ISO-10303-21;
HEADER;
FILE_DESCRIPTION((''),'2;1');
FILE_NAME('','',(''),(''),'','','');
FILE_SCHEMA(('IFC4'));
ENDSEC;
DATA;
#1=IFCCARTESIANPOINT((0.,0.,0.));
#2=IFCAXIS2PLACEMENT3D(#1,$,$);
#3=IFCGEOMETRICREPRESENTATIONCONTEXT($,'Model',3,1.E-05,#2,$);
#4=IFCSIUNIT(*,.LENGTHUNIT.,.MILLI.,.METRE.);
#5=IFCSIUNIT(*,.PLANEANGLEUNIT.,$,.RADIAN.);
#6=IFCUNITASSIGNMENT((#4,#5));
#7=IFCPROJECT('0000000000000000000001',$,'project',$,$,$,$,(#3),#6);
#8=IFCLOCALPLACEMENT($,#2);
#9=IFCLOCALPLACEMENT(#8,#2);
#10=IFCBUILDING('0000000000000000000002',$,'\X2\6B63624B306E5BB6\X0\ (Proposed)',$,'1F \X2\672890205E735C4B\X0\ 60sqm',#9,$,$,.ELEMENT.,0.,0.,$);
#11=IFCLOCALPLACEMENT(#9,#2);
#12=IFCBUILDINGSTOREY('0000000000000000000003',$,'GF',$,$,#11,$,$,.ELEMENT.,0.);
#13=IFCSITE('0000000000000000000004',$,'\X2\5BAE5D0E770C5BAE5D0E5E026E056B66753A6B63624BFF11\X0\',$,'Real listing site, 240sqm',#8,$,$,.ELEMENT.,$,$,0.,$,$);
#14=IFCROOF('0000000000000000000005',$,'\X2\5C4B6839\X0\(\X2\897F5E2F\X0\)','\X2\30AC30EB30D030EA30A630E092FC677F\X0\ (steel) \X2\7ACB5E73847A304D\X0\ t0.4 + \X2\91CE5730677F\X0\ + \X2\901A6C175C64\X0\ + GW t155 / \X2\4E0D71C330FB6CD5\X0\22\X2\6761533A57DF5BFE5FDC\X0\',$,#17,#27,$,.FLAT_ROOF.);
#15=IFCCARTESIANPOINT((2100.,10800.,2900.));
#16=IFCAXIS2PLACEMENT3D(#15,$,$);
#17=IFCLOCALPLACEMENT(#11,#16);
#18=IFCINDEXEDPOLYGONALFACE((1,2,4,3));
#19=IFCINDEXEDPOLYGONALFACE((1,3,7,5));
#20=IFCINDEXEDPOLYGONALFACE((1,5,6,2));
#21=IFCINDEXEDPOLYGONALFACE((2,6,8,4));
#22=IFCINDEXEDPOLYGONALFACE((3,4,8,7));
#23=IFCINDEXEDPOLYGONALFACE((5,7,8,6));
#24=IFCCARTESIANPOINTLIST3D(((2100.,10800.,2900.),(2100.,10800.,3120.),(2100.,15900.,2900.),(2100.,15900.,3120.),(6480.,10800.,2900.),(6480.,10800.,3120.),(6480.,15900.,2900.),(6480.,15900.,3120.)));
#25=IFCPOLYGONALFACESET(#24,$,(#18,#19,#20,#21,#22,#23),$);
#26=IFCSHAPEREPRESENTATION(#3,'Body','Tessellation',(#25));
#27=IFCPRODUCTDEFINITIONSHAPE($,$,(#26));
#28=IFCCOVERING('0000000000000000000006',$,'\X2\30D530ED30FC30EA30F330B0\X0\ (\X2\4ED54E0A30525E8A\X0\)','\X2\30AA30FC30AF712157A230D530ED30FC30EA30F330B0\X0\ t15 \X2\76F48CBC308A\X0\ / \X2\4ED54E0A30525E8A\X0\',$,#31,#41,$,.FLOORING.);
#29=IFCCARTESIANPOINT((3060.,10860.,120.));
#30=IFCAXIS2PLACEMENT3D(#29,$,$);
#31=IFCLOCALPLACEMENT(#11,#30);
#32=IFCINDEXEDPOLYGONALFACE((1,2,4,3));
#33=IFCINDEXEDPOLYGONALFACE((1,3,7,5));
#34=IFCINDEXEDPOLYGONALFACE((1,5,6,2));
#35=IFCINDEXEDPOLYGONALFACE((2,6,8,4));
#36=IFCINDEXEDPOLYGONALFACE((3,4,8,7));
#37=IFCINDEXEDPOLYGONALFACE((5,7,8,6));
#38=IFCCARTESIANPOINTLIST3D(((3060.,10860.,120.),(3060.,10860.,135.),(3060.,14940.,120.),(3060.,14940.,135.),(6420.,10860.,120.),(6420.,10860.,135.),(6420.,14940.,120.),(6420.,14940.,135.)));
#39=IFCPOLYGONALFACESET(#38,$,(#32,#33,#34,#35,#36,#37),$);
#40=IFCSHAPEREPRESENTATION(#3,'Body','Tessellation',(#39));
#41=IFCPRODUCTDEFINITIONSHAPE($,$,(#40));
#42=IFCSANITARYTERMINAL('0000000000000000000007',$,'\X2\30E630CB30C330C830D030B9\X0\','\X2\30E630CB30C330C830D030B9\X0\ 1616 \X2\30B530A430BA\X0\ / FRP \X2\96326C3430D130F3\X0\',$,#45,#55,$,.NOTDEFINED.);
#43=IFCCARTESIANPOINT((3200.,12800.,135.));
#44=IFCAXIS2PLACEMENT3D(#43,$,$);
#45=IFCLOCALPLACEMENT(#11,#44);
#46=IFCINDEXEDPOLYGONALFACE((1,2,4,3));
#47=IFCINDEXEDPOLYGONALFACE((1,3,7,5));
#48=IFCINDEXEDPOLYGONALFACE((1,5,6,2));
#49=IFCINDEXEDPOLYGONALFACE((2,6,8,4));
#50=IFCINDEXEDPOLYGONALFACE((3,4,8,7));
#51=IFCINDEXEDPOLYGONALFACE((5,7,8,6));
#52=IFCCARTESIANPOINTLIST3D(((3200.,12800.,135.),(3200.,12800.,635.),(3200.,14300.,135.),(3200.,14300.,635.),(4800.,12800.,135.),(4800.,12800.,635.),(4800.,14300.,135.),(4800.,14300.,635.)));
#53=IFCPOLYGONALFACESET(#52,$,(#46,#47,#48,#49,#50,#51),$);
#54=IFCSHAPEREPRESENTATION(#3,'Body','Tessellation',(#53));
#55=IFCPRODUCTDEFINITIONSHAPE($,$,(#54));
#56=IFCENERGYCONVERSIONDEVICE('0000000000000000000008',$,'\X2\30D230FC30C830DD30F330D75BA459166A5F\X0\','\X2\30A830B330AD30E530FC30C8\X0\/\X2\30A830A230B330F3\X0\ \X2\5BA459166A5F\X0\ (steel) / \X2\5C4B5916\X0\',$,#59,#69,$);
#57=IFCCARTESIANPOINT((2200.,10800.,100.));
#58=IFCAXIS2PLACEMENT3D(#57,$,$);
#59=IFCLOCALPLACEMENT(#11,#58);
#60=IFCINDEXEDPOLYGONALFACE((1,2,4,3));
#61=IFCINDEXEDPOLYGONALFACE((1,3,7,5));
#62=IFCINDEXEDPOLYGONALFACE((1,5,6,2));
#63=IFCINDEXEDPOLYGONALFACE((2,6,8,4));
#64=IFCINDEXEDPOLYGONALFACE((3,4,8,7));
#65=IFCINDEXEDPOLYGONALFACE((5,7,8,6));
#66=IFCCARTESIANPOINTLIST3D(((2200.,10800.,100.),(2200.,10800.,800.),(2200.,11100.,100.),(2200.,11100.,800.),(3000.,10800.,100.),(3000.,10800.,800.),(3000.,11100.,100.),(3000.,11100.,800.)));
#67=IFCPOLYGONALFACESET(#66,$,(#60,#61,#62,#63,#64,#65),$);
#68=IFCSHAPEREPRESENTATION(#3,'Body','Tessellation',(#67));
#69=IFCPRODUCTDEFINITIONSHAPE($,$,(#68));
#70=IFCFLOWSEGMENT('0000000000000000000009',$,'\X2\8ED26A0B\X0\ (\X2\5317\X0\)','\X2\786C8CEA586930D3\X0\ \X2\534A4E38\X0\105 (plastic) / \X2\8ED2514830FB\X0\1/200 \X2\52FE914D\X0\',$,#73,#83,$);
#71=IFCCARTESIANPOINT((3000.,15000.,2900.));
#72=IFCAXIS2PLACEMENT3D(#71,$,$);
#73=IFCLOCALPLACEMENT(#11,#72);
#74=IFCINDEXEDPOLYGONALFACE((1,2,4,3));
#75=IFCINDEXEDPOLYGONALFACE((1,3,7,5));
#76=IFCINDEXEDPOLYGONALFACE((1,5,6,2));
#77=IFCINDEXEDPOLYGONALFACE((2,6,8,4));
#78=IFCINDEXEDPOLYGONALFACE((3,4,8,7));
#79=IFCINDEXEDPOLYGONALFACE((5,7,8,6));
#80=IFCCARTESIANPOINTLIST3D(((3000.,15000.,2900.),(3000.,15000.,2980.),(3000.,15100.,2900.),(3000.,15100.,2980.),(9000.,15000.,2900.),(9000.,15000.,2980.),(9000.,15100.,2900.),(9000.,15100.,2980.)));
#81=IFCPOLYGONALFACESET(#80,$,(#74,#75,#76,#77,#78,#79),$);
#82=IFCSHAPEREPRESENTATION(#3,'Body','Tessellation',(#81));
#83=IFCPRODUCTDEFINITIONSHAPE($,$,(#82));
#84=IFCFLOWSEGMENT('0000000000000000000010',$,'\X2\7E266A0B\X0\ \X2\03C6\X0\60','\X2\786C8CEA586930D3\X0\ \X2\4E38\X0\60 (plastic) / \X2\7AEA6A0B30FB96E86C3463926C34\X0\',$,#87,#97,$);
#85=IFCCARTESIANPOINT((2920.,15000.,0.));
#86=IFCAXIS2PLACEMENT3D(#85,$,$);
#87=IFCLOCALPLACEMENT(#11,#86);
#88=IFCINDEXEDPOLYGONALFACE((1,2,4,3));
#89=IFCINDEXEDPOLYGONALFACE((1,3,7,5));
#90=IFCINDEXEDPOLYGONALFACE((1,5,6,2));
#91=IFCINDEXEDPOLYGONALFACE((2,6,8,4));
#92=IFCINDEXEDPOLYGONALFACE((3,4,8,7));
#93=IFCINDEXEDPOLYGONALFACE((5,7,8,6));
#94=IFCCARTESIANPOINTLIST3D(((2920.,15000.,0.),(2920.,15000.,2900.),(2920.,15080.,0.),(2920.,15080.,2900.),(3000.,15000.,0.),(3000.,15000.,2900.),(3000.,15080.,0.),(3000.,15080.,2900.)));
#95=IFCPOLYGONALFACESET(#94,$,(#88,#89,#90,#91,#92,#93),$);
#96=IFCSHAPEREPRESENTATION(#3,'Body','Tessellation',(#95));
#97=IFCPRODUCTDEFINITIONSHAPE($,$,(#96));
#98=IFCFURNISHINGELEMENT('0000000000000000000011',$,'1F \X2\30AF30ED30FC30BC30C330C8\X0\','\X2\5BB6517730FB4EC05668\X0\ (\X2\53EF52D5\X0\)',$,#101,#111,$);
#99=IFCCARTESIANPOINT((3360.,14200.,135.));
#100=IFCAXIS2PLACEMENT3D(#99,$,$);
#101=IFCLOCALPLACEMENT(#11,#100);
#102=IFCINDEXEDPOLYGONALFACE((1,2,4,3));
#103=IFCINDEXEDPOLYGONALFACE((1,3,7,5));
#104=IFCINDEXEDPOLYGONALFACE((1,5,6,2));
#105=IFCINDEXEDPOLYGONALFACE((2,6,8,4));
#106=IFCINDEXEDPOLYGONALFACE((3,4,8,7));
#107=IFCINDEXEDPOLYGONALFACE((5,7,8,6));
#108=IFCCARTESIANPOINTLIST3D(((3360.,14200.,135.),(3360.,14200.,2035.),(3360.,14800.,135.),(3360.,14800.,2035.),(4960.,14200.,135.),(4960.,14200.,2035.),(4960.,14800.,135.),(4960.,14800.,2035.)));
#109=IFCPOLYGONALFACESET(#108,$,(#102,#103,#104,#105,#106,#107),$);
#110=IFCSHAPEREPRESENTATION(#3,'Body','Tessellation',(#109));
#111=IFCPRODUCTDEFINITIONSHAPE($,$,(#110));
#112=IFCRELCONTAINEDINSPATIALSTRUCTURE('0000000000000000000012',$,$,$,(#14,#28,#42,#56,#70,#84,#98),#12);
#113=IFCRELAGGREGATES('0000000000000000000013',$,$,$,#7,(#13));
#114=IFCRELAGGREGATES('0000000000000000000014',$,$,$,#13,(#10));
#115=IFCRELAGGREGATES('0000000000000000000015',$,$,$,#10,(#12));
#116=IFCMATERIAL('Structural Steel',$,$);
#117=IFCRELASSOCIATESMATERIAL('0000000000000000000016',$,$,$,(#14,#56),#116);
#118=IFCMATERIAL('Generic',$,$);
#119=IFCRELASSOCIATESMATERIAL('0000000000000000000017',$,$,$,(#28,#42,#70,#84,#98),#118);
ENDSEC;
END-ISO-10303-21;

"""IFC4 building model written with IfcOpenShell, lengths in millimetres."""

from ifc_helpers import new_model, si_unit, frame, frame_2d, origin, place, context, project, spatial, rectangle, extrude, material, element, save


model = new_model("IFC4")

# Units and contexts
model_context = context("Model", 3, precision=1e-05, world=origin())
ifc_project = project(units=[si_unit("LENGTHUNIT", "METRE", prefix="MILLI"), si_unit("PLANEANGLEUNIT", "RADIAN")], contexts=[model_context])

# Site, building, storey
site_placement = place(None, origin())
site = spatial("IfcSite", under=ifc_project, at=site_placement, Name="宮崎県宮崎市清武町正手１", ObjectType="Real listing site, 240sqm", CompositionType="ELEMENT", RefElevation=0.0)
building_placement = place(site_placement, origin())
building = spatial("IfcBuilding", under=site, at=building_placement, Name="正手の家 (Proposed)", ObjectType="1F 木造平屋 60sqm", CompositionType="ELEMENT", ElevationOfRefHeight=0.0, ElevationOfTerrain=0.0)
storey_placement = place(building_placement, origin())
storey = spatial("IfcBuildingStorey", under=building, at=storey_placement, Name="GF", CompositionType="ELEMENT", Elevation=0.0)

# Roof
ifc_material_1 = material(Name="Structural Steel")
roof_placement = place(storey_placement, frame((2100.0, 10800.0, 2900.0)))
element("IfcRoof", 1, at=roof_placement, inside=storey, material=ifc_material_1, Name="屋根(西帯)", Description="ガルバリウム鋼板 (steel) 立平葺き t0.4 + 野地板 + 通気層 + GW t155 / 不燃・法22条区域対応", PredefinedType="FLAT_ROOF", context=model_context, shape_type="SweptSolid", body=[
    extrude(rectangle(XDim=4380.0, YDim=5100.0, at=frame_2d((2190.0, 2550.0))), frame((2100.0, 10800.0, 2900.0)), (0.0, 0.0, 1.0), 220.0),
])

# Covering
ifc_material_2 = material(Name="Generic")
covering_placement = place(storey_placement, frame((3060.0, 10860.0, 120.0)))
element("IfcCovering", 2, at=covering_placement, inside=storey, material=ifc_material_2, Name="フローリング (仕上げ床)", Description="オーク無垢フローリング t15 直貼り / 仕上げ床", PredefinedType="FLOORING", context=model_context, shape_type="SweptSolid", body=[
    extrude(rectangle(XDim=3360.0, YDim=4080.0, at=frame_2d((1680.0, 2040.0))), frame((3060.0, 10860.0, 120.0)), (0.0, 0.0, 1.0), 15.0),
])

# Sanitary terminal
sanitary_terminal_placement = place(storey_placement, frame((3200.0, 12800.0, 135.0)))
element("IfcSanitaryTerminal", 3, at=sanitary_terminal_placement, inside=storey, material=ifc_material_2, Name="ユニットバス", Description="ユニットバス 1616 サイズ / FRP 防水パン", PredefinedType="NOTDEFINED", context=model_context, shape_type="SweptSolid", body=[
    extrude(rectangle(XDim=1600.0, YDim=1500.0, at=frame_2d((800.0, 750.0))), frame((3200.0, 12800.0, 135.0)), (0.0, 0.0, 1.0), 500.0),
])

# Energy conversion device
energy_conversion_device_placement = place(storey_placement, frame((2200.0, 10800.0, 100.0)))
element("IfcEnergyConversionDevice", 4, at=energy_conversion_device_placement, inside=storey, material=ifc_material_1, Name="ヒートポンプ室外機", Description="エコキュート/エアコン 室外機 (steel) / 屋外", context=model_context, shape_type="SweptSolid", body=[
    extrude(rectangle(XDim=800.0, YDim=300.0, at=frame_2d((400.0, 150.0))), frame((2200.0, 10800.0, 100.0)), (0.0, 0.0, 1.0), 700.0),
])

# Flow segments
flow_segment_1_placement = place(storey_placement, frame((3000.0, 15000.0, 2900.0)))
element("IfcFlowSegment", 5, at=flow_segment_1_placement, inside=storey, material=ifc_material_2, Name="軒樋 (北)", Description="硬質塩ビ 半丸105 (plastic) / 軒先・1/200 勾配", context=model_context, shape_type="SweptSolid", body=[
    extrude(rectangle(XDim=6000.0, YDim=100.0, at=frame_2d((3000.0, 50.0))), frame((3000.0, 15000.0, 2900.0)), (0.0, 0.0, 1.0), 80.0),
])
flow_segment_2_placement = place(storey_placement, frame((2920.0, 15000.0, 0.0)))
element("IfcFlowSegment", 6, at=flow_segment_2_placement, inside=storey, material=ifc_material_2, Name="縦樋 φ60", Description="硬質塩ビ 丸60 (plastic) / 竪樋・雨水排水", context=model_context, shape_type="SweptSolid", body=[
    extrude(rectangle(XDim=80.0, YDim=80.0, at=frame_2d((40.0, 40.0))), frame((2920.0, 15000.0, 0.0)), (0.0, 0.0, 1.0), 2900.0),
])

# Furnishing element
furnishing_placement = place(storey_placement, frame((3360.0, 14200.0, 135.0)))
element("IfcFurnishingElement", 7, at=furnishing_placement, inside=storey, material=ifc_material_2, Name="1F クローゼット", Description="家具・什器 (可動)", context=model_context, shape_type="SweptSolid", body=[
    extrude(rectangle(XDim=1600.0, YDim=600.0, at=frame_2d((800.0, 300.0))), frame((3360.0, 14200.0, 135.0)), (0.0, 0.0, 1.0), 1900.0),
])

save(model, "model.ifc")
